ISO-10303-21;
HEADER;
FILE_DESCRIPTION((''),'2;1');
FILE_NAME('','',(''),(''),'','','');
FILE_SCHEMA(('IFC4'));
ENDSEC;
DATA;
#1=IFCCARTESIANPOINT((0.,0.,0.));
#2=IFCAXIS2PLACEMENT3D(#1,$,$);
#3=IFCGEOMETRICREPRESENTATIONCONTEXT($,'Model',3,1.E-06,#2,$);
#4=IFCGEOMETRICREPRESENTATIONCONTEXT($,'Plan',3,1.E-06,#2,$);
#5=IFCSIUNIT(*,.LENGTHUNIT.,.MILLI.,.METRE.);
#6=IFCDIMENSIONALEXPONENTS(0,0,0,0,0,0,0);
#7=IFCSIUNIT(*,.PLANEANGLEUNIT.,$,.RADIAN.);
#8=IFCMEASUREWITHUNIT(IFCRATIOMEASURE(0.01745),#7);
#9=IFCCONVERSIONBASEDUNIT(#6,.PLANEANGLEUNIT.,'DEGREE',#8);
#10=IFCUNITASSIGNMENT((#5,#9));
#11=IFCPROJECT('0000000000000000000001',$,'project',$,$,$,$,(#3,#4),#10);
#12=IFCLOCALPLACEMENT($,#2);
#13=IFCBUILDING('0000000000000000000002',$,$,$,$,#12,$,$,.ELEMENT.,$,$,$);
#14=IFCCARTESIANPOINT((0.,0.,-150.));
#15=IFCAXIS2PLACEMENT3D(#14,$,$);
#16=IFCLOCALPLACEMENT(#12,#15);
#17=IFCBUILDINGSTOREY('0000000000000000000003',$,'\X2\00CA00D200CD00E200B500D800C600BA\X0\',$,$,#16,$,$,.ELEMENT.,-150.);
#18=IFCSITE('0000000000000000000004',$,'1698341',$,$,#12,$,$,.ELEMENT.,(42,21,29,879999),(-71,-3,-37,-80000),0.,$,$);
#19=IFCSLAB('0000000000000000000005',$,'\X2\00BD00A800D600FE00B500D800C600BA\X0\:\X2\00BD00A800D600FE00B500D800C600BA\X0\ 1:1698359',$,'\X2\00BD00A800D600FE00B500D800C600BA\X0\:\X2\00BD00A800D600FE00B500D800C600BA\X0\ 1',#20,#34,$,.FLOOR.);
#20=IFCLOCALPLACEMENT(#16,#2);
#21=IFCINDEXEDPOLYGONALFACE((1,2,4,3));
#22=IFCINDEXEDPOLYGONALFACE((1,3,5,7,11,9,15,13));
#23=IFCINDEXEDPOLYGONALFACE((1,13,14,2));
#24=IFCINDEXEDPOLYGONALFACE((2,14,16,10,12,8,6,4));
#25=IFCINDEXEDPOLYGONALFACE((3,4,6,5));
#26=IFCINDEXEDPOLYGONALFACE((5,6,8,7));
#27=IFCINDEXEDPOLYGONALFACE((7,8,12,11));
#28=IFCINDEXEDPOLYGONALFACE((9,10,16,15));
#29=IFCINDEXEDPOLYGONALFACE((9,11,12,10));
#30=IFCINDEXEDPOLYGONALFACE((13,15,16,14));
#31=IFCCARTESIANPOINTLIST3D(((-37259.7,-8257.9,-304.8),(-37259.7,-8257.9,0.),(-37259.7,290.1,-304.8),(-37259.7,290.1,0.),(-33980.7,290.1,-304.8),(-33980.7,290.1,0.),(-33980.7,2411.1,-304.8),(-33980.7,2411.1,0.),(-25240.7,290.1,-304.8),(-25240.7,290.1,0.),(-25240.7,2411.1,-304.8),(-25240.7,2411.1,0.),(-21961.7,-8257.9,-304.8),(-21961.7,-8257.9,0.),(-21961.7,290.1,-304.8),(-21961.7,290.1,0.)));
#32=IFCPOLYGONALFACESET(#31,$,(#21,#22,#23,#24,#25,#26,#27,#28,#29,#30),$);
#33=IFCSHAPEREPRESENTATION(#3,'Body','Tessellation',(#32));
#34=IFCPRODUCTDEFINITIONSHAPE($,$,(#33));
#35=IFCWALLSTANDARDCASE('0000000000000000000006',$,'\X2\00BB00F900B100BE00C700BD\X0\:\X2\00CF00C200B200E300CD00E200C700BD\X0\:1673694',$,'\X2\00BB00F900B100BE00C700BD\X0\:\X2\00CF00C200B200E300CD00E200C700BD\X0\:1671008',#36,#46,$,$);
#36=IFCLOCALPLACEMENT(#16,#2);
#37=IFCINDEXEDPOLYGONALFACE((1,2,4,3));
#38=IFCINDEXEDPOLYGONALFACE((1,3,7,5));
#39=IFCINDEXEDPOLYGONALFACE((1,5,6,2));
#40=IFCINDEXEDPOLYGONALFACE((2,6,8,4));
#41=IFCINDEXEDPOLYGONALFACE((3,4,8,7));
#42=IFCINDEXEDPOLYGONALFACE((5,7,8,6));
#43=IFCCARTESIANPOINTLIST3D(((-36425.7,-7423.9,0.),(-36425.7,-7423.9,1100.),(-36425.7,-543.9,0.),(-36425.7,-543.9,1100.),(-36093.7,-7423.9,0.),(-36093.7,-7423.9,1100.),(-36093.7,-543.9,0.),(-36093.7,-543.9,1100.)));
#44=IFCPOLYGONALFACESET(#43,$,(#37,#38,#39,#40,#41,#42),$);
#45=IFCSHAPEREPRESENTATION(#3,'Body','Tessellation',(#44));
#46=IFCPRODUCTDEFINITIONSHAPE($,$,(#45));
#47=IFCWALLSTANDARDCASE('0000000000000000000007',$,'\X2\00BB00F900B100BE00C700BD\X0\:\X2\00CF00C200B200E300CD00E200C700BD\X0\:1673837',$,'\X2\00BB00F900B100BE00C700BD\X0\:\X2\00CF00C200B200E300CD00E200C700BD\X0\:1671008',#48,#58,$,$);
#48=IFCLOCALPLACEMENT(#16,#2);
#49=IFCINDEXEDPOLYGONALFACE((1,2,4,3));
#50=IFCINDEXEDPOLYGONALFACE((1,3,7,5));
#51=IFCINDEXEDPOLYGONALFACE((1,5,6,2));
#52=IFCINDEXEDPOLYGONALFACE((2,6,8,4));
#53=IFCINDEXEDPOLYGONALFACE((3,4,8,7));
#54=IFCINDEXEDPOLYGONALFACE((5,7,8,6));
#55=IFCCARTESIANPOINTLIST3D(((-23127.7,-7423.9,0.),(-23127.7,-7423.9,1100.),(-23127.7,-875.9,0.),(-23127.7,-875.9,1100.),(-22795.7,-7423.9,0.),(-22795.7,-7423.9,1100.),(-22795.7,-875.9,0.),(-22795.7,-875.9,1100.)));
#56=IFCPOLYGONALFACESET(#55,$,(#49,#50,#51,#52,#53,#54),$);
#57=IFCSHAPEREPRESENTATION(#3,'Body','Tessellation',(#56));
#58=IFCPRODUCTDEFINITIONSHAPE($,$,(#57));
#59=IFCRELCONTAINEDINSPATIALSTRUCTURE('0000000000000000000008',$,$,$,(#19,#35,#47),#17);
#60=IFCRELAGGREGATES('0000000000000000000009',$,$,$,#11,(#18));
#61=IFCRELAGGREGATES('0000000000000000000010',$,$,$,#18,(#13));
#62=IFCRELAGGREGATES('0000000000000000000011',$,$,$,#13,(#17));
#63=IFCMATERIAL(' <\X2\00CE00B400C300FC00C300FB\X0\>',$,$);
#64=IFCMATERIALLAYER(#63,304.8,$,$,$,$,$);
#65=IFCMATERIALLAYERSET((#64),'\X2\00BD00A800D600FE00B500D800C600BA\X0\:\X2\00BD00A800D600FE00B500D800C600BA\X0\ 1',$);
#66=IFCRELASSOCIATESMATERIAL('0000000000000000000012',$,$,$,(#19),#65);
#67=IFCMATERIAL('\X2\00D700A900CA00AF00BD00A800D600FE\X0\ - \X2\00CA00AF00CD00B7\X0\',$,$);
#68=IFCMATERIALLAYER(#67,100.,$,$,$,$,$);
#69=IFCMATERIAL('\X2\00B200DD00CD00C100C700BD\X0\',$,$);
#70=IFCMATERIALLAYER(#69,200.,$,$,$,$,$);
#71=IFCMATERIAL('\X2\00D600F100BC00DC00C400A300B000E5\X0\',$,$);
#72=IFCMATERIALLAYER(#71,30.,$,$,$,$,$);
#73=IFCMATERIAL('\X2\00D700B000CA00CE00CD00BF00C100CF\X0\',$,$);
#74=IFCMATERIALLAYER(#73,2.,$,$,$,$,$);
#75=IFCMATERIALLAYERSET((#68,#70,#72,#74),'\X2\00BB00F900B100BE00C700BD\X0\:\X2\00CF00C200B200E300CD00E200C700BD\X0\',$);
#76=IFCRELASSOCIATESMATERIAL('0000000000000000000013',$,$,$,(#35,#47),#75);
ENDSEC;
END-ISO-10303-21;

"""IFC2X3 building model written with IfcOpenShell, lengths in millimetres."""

from ifc_helpers import new_model, entity, si_unit, converted_unit, frame, frame_2d, origin, place, context, project, spatial, polyline, rectangle, outline, extrude, material, layer, layer_set, layer_usage, element, save


model = new_model("IFC2X3")

# Units and contexts
model_context = context("Model", 3, precision=1e-06, world=origin())
plan_context = context("Plan", 3, precision=1e-06, world=origin())
ifc_project = project(units=[si_unit("LENGTHUNIT", "METRE", prefix="MILLI"), converted_unit("PLANEANGLEUNIT", "DEGREE", entity("IfcRatioMeasure", 0.01745), si_unit("PLANEANGLEUNIT", "RADIAN"), dimensions=[0, 0, 0, 0, 0, 0, 0])], contexts=[model_context, plan_context])

# Site, building, storey
placement_1 = place(None, origin())
site = spatial("IfcSite", under=ifc_project, at=placement_1, Name="1698341", CompositionType="ELEMENT", RefLatitude=(42, 21, 29, 879999), RefLongitude=(-71, -3, -37, -80000), RefElevation=0.0)
building = spatial("IfcBuilding", under=site, at=placement_1, CompositionType="ELEMENT")
storey_placement = place(placement_1, frame((0.0, 0.0, -150.0)))
storey = spatial("IfcBuildingStorey", under=building, at=storey_placement, Name="ÊÒÍâµØÆº", CompositionType="ELEMENT", Elevation=-150.0)

# Slab
ifc_material_1 = material(Name=" <Î´ÃüÃû>")
ifc_layer_1 = layer(ifc_material_1, 304.8)
ifc_layer_set_1 = layer_set([ifc_layer_1], Name="½¨ÖþµØÆº:½¨ÖþµØÆº 1")
ifc_layer_usage_1 = layer_usage(ifc_layer_set_1, "AXIS3", "NEGATIVE", 0.0)
slab_placement = place(storey_placement, frame((-37259.7, -8257.9, -304.8)))
element("IfcSlab", 1, at=slab_placement, inside=storey, material=ifc_layer_usage_1, Name="½¨ÖþµØÆº:½¨ÖþµØÆº 1:1698359", ObjectType="½¨ÖþµØÆº:½¨ÖþµØÆº 1", PredefinedType="FLOOR", context=model_context, shape_type="SweptSolid", body=[
    extrude(outline(polyline([(7649.0, 3213.5), (4370.0, 3213.5), (4370.0, 5334.5), (-4370.0, 5334.5), (-4370.0, 3213.5), (-7649.0, 3213.5), (-7649.0, -5334.5), (7649.0, -5334.5), (7649.0, 3213.5)])), frame((7649.0, 5334.5, 304.8), z_axis=(0.0, 0.0, -1.0), x_axis=(-1.0, 0.0, 0.0)), (0.0, 0.0, 1.0), 304.8),
])

# Wall
ifc_material_2 = material(Name="×©Ê¯½¨Öþ - Ê¯Í·")
ifc_layer_2 = layer(ifc_material_2, 100.0)
ifc_material_3 = material(Name="²ÝÍÁÇ½")
ifc_layer_3 = layer(ifc_material_3, 200.0)
ifc_material_4 = material(Name="Öñ¼ÜÄ£°å")
ifc_layer_4 = layer(ifc_material_4, 30.0)
ifc_material_5 = material(Name="×°ÊÎÍ¿ÁÏ")
ifc_layer_5 = layer(ifc_material_5, 2.0)
ifc_layer_set_2 = layer_set([ifc_layer_2, ifc_layer_3, ifc_layer_4, ifc_layer_5], Name="»ù±¾Ç½:ÏÂ²ãÍâÇ½")
ifc_layer_usage_2 = layer_usage(ifc_layer_set_2, "AXIS2", "NEGATIVE", 166.0)
wall_1_placement = place(storey_placement, frame((-36259.7, -7423.9, 0.0), z_axis=(0.0, 0.0, 1.0), x_axis=(0.0, 1.0, 0.0)))
element("IfcWallStandardCase", 2, at=wall_1_placement, inside=storey, material=ifc_layer_usage_2, Name="»ù±¾Ç½:ÏÂ²ãÍâÇ½:1673694", ObjectType="»ù±¾Ç½:ÏÂ²ãÍâÇ½:1671008", context=model_context, shape_type="SweptSolid", body=[
    extrude(rectangle(XDim=6880.0, YDim=332.0, at=frame_2d((3440.0, 0.0), x_axis=(-1.0, 0.0))), origin(), (0.0, 0.0, 1.0), 1100.0),
])

# Wall
wall_2_placement = place(storey_placement, frame((-22961.7, -875.9, 0.0), z_axis=(0.0, 0.0, 1.0), x_axis=(0.0, -1.0, 0.0)))
element("IfcWallStandardCase", 3, at=wall_2_placement, inside=storey, material=ifc_layer_usage_2, Name="»ù±¾Ç½:ÏÂ²ãÍâÇ½:1673837", ObjectType="»ù±¾Ç½:ÏÂ²ãÍâÇ½:1671008", context=model_context, shape_type="SweptSolid", body=[
    extrude(rectangle(XDim=6548.0, YDim=332.0, at=frame_2d((3274.0, 0.0), x_axis=(-1.0, 0.0))), origin(), (0.0, 0.0, 1.0), 1100.0),
])

save(model, "model.ifc")
